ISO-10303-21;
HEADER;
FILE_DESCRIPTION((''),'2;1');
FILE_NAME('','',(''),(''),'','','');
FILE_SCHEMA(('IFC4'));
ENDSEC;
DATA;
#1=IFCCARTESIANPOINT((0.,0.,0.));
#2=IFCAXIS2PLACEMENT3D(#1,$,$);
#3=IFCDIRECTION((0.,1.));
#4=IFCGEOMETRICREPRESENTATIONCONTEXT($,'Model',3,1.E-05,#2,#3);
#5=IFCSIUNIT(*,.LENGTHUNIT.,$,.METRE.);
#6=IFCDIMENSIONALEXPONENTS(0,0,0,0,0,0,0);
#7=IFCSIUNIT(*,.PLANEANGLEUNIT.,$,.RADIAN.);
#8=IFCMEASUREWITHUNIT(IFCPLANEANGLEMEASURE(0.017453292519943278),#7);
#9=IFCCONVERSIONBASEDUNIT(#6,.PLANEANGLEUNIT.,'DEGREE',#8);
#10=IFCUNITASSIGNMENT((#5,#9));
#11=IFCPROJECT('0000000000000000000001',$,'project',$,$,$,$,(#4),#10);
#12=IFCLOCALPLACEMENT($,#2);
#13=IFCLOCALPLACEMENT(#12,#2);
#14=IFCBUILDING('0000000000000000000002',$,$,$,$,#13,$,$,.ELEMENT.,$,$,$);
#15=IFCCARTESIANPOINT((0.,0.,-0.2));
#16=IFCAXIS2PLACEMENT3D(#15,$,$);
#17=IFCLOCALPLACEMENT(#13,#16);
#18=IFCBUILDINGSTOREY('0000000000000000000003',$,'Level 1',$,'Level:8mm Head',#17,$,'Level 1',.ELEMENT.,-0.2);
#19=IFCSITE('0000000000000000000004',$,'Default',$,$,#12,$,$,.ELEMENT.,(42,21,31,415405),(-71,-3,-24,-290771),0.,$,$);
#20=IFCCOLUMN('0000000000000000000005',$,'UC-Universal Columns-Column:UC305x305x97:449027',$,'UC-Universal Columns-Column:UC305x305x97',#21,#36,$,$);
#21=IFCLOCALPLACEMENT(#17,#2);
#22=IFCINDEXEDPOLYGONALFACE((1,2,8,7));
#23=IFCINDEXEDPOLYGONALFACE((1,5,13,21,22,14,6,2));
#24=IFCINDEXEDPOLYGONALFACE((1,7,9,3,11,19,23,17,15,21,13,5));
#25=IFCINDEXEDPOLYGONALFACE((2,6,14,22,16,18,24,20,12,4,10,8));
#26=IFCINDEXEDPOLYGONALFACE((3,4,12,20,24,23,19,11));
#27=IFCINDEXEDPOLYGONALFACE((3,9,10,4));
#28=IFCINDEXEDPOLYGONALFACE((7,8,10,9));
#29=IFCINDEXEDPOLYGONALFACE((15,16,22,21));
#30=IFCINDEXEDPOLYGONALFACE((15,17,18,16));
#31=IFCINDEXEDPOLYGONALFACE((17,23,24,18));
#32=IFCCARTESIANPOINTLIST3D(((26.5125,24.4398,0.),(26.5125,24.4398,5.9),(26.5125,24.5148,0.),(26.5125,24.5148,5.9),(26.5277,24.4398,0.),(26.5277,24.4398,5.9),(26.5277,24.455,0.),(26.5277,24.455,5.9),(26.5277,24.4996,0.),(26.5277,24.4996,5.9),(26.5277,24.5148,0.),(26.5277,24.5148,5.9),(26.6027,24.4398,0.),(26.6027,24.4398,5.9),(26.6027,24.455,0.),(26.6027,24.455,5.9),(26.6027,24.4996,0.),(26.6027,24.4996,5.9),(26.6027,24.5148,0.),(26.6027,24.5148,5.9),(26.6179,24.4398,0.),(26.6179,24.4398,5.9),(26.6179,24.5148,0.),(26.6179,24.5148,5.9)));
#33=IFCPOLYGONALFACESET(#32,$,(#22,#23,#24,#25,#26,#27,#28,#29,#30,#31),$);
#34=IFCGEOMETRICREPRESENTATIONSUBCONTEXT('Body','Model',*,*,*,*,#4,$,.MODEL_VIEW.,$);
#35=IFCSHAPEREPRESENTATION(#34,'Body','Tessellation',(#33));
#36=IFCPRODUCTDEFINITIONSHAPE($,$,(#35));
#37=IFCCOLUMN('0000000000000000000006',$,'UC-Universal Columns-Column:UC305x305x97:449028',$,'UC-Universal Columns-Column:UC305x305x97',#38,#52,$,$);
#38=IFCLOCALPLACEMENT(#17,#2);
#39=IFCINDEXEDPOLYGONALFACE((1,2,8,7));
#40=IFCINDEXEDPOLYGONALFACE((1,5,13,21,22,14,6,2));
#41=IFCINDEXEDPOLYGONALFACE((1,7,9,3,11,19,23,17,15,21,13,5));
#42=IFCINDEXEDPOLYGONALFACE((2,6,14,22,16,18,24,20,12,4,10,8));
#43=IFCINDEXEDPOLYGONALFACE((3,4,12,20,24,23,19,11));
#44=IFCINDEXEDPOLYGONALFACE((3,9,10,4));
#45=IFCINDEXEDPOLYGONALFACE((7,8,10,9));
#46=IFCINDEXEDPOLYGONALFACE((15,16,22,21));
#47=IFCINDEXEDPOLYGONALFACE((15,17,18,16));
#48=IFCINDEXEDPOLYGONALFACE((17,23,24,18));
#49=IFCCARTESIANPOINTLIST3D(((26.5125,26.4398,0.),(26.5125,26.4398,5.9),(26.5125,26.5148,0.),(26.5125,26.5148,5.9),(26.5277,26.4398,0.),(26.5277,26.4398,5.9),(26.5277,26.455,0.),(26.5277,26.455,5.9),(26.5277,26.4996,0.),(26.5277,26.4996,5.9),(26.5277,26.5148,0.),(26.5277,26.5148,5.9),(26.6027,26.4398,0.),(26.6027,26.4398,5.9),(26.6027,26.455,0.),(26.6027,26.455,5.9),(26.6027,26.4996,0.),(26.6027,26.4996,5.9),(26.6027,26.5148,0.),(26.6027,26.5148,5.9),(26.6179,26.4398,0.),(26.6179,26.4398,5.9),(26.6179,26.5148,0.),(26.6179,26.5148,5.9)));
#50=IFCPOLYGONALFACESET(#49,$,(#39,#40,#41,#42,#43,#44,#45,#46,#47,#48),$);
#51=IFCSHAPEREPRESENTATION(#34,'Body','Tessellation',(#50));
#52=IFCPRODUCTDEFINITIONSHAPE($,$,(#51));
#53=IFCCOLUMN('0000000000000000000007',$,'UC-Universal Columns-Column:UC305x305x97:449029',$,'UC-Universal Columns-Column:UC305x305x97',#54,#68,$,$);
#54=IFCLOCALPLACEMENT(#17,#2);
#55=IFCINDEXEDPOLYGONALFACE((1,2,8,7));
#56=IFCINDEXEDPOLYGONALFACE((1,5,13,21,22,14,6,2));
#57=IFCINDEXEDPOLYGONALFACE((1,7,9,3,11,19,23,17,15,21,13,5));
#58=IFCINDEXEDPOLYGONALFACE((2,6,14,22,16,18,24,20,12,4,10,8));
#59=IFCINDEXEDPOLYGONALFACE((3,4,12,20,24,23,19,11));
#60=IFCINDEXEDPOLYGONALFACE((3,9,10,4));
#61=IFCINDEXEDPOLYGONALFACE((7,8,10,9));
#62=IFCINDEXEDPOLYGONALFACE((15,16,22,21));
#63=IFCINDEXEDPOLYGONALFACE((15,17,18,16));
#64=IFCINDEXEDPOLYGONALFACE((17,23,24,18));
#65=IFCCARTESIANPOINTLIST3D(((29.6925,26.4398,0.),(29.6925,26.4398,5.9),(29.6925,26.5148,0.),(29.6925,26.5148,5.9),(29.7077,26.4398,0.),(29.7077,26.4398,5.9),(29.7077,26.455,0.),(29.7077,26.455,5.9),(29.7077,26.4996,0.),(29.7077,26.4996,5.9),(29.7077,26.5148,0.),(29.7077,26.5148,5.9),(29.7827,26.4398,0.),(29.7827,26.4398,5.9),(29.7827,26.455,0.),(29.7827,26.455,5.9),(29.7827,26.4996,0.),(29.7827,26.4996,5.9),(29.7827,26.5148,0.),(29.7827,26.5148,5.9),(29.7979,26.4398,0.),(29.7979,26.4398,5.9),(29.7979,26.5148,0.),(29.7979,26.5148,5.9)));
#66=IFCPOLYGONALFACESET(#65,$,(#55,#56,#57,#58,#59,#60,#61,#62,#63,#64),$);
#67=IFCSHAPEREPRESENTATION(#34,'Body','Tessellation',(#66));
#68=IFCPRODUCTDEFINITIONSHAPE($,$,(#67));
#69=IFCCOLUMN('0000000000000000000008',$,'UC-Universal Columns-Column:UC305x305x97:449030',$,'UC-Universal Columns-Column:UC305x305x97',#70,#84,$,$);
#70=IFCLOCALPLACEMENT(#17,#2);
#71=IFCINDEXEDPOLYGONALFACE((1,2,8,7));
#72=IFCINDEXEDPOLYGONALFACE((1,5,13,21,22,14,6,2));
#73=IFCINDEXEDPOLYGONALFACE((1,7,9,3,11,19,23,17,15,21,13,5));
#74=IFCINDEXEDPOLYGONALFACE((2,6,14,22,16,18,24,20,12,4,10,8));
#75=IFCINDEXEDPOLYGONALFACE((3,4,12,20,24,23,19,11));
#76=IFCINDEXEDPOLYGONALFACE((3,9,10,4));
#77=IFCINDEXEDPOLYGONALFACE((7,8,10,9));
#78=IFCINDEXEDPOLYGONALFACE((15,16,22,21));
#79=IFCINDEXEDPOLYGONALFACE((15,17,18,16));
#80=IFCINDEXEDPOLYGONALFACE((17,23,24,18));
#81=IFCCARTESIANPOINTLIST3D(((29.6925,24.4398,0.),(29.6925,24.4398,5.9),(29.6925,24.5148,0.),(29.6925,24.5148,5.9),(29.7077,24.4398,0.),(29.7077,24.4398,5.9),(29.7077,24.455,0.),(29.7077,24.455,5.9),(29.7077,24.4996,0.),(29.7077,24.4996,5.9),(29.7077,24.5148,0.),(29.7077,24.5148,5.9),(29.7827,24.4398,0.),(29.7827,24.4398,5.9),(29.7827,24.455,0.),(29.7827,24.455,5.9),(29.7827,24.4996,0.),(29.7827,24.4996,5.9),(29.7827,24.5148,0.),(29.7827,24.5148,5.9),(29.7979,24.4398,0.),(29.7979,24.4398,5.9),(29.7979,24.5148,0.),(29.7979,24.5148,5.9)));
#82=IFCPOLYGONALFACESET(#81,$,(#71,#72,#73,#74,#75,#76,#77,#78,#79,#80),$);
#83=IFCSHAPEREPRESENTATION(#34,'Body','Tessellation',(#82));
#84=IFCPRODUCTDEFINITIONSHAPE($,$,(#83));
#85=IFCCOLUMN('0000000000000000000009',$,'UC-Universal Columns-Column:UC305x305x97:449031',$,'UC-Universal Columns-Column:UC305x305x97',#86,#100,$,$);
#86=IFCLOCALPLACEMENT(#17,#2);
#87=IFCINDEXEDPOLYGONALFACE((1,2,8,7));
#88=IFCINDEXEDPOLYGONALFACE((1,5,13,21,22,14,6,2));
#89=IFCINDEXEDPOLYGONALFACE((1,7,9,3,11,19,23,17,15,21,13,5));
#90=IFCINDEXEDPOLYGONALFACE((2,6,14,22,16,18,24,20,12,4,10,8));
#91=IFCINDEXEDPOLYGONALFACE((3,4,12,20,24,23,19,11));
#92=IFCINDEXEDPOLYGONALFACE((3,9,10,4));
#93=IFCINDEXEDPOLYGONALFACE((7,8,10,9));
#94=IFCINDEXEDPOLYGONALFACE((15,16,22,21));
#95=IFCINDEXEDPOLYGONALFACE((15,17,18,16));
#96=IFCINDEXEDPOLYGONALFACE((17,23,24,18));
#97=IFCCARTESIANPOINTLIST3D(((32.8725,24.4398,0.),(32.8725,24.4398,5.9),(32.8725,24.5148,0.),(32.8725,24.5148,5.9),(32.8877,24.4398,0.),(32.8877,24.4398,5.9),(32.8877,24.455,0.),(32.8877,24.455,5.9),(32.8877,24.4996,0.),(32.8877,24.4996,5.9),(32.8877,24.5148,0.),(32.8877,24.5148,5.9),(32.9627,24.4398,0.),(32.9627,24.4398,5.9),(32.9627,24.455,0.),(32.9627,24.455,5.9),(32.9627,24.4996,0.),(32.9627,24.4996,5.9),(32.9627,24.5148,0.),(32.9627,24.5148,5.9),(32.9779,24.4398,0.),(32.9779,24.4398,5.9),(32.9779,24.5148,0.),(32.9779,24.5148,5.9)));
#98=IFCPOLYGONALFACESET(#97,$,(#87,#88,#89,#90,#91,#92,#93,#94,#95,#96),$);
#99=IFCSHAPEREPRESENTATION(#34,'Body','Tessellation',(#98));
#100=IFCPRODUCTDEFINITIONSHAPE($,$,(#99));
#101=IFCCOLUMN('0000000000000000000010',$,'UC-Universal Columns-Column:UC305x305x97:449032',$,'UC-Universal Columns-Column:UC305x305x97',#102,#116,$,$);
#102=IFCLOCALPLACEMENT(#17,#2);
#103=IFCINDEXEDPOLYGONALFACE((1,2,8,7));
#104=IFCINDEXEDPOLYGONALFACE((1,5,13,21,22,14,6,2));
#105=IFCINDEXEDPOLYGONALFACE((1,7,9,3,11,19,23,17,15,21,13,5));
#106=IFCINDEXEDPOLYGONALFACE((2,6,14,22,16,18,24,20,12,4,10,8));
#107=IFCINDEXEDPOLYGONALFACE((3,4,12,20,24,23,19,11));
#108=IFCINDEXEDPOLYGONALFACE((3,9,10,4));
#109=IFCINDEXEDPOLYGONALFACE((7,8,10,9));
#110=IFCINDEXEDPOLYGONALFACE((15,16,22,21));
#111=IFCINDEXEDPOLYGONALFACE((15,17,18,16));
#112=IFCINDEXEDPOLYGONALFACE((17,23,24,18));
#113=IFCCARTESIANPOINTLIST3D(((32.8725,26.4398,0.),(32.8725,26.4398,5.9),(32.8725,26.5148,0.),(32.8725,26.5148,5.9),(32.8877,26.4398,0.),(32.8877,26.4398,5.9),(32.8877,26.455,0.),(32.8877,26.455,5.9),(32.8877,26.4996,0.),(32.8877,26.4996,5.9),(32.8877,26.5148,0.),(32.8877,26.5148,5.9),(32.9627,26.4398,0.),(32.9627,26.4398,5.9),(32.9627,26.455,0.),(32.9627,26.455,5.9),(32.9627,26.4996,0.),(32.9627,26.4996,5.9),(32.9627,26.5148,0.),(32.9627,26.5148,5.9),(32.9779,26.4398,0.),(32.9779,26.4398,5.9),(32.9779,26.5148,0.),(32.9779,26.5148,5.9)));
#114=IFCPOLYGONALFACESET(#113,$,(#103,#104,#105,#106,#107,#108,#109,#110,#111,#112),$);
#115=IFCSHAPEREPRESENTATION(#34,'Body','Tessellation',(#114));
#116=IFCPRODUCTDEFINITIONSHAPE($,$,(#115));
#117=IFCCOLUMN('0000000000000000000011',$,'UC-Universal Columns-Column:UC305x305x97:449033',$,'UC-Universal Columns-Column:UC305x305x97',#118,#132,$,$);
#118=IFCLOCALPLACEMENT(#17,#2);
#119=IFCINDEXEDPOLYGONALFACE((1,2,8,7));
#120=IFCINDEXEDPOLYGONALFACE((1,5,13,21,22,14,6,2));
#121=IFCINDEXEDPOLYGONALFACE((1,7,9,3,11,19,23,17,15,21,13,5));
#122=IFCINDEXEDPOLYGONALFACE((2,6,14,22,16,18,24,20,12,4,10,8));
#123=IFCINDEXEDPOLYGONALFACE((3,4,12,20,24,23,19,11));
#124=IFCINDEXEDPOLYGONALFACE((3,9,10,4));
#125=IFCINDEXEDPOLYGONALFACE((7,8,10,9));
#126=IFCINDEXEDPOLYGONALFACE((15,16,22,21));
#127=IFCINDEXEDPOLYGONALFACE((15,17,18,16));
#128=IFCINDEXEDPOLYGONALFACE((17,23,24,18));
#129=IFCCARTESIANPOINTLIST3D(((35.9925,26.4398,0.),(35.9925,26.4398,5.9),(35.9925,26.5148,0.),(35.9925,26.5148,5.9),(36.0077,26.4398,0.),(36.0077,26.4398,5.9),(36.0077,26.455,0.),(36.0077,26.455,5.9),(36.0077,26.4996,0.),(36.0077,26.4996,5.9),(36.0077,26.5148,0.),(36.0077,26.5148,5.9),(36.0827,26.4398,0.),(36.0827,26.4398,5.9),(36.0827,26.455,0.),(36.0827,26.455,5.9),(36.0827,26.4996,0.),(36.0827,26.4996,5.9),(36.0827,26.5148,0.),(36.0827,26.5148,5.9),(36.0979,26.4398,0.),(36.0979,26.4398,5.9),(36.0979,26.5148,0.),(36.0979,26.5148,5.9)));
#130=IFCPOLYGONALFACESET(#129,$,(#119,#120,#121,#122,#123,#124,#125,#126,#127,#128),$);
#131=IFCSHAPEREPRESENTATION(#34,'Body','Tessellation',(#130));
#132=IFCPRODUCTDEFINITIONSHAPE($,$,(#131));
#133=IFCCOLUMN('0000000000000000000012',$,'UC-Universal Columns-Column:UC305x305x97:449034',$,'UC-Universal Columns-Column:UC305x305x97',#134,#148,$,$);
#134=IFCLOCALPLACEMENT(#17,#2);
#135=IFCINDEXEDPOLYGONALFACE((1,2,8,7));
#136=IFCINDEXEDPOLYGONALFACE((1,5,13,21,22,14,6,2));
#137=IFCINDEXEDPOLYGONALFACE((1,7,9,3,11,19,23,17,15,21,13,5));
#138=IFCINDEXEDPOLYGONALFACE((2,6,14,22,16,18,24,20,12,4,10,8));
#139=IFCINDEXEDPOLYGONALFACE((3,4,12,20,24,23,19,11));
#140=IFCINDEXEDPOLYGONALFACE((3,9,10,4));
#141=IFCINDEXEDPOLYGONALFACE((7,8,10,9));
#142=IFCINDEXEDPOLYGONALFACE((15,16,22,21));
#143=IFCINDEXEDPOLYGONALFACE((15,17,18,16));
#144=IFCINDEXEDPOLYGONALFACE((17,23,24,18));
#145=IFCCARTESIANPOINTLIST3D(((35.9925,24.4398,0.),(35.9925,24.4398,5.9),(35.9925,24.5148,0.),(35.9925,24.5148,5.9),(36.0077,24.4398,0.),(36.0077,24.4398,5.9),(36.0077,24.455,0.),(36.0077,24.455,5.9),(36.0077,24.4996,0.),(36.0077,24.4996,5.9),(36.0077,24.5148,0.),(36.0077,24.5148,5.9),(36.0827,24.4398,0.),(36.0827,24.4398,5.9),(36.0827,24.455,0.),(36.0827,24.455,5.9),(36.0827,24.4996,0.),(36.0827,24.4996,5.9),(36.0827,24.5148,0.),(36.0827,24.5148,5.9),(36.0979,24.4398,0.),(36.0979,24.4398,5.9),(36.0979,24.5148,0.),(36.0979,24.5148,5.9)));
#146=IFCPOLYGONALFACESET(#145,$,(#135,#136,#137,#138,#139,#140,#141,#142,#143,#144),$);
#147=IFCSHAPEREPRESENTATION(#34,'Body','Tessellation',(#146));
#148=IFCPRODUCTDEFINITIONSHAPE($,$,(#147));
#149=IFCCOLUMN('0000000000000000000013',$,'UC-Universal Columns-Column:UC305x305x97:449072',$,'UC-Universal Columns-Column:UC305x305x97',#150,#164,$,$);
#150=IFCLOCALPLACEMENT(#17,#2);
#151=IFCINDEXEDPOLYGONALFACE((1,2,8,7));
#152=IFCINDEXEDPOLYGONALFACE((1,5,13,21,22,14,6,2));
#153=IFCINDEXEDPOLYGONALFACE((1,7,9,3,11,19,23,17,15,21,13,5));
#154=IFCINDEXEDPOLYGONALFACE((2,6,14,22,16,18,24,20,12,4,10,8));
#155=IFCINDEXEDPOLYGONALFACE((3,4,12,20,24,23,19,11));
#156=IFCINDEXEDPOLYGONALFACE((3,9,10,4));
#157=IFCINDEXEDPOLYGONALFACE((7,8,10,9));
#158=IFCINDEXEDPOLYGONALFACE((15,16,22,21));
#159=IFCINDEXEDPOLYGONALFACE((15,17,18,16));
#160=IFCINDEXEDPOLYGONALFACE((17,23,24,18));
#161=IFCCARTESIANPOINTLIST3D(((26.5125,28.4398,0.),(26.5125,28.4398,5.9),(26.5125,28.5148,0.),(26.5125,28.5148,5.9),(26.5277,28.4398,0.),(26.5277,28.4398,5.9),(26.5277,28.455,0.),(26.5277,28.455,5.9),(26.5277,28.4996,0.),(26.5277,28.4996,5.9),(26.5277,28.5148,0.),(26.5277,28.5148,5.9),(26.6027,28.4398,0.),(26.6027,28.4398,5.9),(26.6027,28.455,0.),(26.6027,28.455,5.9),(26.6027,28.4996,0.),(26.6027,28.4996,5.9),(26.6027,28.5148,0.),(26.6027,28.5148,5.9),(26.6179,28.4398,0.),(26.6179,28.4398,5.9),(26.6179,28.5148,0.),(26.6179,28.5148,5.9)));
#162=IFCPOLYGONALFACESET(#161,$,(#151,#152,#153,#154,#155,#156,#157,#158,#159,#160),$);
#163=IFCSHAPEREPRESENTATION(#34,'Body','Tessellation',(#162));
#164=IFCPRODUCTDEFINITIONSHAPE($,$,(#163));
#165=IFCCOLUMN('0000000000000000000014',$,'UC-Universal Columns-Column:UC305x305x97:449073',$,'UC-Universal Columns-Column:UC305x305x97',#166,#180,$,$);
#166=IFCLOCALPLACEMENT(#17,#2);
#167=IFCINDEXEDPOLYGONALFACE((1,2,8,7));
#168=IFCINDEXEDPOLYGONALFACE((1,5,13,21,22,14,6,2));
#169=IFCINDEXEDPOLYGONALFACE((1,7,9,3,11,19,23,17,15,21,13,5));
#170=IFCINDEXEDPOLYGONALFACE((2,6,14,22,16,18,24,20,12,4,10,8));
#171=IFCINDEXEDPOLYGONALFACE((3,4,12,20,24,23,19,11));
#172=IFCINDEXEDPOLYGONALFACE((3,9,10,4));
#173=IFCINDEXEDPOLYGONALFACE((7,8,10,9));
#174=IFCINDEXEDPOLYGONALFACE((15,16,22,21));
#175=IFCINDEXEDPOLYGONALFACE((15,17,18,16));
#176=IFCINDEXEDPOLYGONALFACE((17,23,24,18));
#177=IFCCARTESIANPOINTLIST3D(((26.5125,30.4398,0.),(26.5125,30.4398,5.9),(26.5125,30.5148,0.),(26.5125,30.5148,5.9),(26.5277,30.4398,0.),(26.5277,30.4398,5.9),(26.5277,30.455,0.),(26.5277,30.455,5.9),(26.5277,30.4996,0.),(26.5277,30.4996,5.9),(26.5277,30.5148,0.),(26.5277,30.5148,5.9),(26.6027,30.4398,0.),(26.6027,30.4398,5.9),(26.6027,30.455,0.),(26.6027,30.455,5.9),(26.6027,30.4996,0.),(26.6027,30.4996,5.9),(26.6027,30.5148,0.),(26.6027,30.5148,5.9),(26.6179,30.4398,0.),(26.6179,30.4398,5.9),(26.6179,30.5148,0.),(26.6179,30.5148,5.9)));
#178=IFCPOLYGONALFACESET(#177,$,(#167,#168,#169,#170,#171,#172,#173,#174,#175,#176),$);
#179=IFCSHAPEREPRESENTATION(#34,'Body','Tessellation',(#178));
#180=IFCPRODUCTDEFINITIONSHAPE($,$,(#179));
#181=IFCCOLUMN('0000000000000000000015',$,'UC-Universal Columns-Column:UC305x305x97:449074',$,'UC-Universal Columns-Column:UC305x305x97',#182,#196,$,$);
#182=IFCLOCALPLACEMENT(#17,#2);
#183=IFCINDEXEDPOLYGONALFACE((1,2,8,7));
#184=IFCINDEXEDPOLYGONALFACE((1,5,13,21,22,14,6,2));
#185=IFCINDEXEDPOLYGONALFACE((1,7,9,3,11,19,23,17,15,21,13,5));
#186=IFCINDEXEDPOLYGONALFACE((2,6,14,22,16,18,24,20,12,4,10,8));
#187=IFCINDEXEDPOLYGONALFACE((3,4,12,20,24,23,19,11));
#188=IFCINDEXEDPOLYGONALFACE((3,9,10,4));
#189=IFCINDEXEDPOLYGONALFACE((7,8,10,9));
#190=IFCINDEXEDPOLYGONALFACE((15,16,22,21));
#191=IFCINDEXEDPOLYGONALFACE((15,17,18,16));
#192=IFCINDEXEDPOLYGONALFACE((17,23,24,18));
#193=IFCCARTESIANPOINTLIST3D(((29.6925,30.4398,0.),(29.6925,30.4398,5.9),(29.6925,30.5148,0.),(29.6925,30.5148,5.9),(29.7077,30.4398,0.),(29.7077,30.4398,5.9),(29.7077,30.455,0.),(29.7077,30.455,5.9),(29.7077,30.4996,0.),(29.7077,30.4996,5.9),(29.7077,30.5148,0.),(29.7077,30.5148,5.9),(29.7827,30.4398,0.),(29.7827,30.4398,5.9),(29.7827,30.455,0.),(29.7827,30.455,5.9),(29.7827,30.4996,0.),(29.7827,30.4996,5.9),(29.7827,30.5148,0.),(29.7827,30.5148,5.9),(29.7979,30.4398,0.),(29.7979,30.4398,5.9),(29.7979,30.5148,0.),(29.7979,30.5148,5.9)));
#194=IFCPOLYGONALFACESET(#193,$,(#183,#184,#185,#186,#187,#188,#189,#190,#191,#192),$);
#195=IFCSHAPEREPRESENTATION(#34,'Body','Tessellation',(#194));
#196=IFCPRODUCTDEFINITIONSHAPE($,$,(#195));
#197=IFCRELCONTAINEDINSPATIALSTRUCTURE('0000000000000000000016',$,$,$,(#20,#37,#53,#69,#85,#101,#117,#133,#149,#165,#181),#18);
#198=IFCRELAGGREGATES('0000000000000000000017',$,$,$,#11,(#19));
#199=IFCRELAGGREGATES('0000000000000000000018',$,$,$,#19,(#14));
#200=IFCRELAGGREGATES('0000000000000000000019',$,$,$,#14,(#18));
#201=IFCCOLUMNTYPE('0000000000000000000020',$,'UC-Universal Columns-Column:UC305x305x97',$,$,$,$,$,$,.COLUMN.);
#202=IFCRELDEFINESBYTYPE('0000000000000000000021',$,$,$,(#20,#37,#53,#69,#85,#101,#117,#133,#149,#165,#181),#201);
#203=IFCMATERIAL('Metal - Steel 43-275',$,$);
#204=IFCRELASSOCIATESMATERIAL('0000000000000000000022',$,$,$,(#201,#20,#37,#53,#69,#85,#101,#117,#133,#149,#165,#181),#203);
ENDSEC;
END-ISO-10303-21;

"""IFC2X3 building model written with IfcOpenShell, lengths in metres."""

from ifc_helpers import new_model, entity, si_unit, converted_unit, direction, frame, frame_2d, origin, place, context, subcontext, project, spatial, polyline, circle_curve, parameter, trimmed, segment, composite_curve, outline, extrude, source, transform, mapped, material, type_object, type_shapes, element, save


model = new_model("IFC2X3")

# Units and contexts
model_context = context("Model", 3, precision=1e-05, world=origin(), true_north=direction((0.0, 1.0)))
body_context = subcontext(model_context, "Body", "Model", "MODEL_VIEW")
ifc_project = project(units=[si_unit("LENGTHUNIT", "METRE"), converted_unit("PLANEANGLEUNIT", "DEGREE", entity("IfcPlaneAngleMeasure", 0.017453292519943278), si_unit("PLANEANGLEUNIT", "RADIAN"), dimensions=[0, 0, 0, 0, 0, 0, 0])], contexts=[model_context])

# Site, building, storey
site_placement = place(None, origin())
site = spatial("IfcSite", under=ifc_project, at=site_placement, Name="Default", CompositionType="ELEMENT", RefLatitude=(42, 21, 31, 415405), RefLongitude=(-71, -3, -24, -290771), RefElevation=0.0)
building_placement = place(site_placement, origin())
building = spatial("IfcBuilding", under=site, at=building_placement, CompositionType="ELEMENT")
storey_placement = place(building_placement, frame((0.0, 0.0, -0.2)))
storey = spatial("IfcBuildingStorey", under=building, at=storey_placement, Name="Level 1", ObjectType="Level:8mm Head", LongName="Level 1", CompositionType="ELEMENT", Elevation=-0.2)

# Columns
ifc_material = material(Name="Metal - Steel 43-275")
column_type = type_object("IfcColumnType", Name="UC-Universal Columns-Column:UC305x305x97", PredefinedType="COLUMN", material=ifc_material)
shared_shape = source(origin(), body_context, "Body", "SweptSolid", [
    extrude(outline(composite_curve([segment(polyline([(-0.0375, -0.0375), (0.0375, -0.0375)]), True, "CONTINUOUS"), segment(polyline([(0.0375, -0.0375), (0.0527, -0.0375)]), True, "CONTINUOUS"), segment(trimmed(circle_curve(frame_2d((0.0527, -0.0223), x_axis=(-1.0, 0.0)), 0.0152), [parameter(0.0)], [parameter(90.0)], True, "PARAMETER"), False, "CONTINUOUS"), segment(polyline([(0.0375, -0.0223), (0.0375, 0.0223)]), True, "CONTINUOUS"), segment(trimmed(circle_curve(frame_2d((0.0527, 0.0223), x_axis=(-1.0, 0.0)), 0.0152), [parameter(270.0)], [parameter(0.0)], True, "PARAMETER"), False, "CONTINUOUS"), segment(polyline([(0.0527, 0.0375), (0.0375, 0.0375)]), True, "CONTINUOUS"), segment(polyline([(0.0375, 0.0375), (-0.0375, 0.0375)]), True, "CONTINUOUS"), segment(polyline([(-0.0375, 0.0375), (-0.0527, 0.0375)]), True, "CONTINUOUS"), segment(trimmed(circle_curve(frame_2d((-0.0527, 0.0223), x_axis=(-1.0, 0.0)), 0.0152), [parameter(180.0)], [parameter(270.0)], True, "PARAMETER"), False, "CONTINUOUS"), segment(polyline([(-0.0375, 0.0223), (-0.0375, -0.0223)]), True, "CONTINUOUS"), segment(trimmed(circle_curve(frame_2d((-0.0527, -0.0223), x_axis=(-1.0, 0.0)), 0.0152), [parameter(90.0)], [parameter(180.0)], True, "PARAMETER"), False, "CONTINUOUS"), segment(polyline([(-0.0527, -0.0375), (-0.0375, -0.0375)]), True, "CONTINUOUS")], self_intersect=False)), frame((0.0, 0.0, -0.2), z_axis=(0.0, 0.0, 1.0), x_axis=(-1.0, 0.0, 0.0)), (0.0, 0.0, 1.0), 5.9),
])
type_shapes(column_type, [shared_shape])
for number, where, z_axis, x_axis, name in (
    (1, (26.5652, 24.4773, 0.2), (0.0, 0.0, 1.0), (-1.0, 0.0, 0.0), "UC-Universal Columns-Column:UC305x305x97:449027"),
    (2, (26.5652, 26.4773, 0.2), (0.0, 0.0, 1.0), (-1.0, 0.0, 0.0), "UC-Universal Columns-Column:UC305x305x97:449028"),
    (3, (29.7452, 26.4773, 0.2), (0.0, 0.0, 1.0), (-1.0, 0.0, 0.0), "UC-Universal Columns-Column:UC305x305x97:449029"),
    (4, (29.7452, 24.4773, 0.2), (0.0, 0.0, 1.0), (-1.0, 0.0, 0.0), "UC-Universal Columns-Column:UC305x305x97:449030"),
    (5, (32.9252, 24.4773, 0.2), (0.0, 0.0, 1.0), (-1.0, 0.0, 0.0), "UC-Universal Columns-Column:UC305x305x97:449031"),
    (6, (32.9252, 26.4773, 0.2), (0.0, 0.0, 1.0), (-1.0, 0.0, 0.0), "UC-Universal Columns-Column:UC305x305x97:449032"),
    (7, (36.0452, 26.4773, 0.2), (0.0, 0.0, 1.0), (-1.0, 0.0, 0.0), "UC-Universal Columns-Column:UC305x305x97:449033"),
    (8, (36.0452, 24.4773, 0.2), (0.0, 0.0, 1.0), (-1.0, 0.0, 0.0), "UC-Universal Columns-Column:UC305x305x97:449034"),
    (9, (26.5652, 28.4773, 0.2), (0.0, 0.0, 1.0), (-1.0, 0.0, 0.0), "UC-Universal Columns-Column:UC305x305x97:449072"),
    (10, (26.5652, 30.4773, 0.2), (0.0, 0.0, 1.0), (-1.0, 0.0, 0.0), "UC-Universal Columns-Column:UC305x305x97:449073"),
    (11, (29.7452, 30.4773, 0.2), (0.0, 0.0, 1.0), (-1.0, 0.0, 0.0), "UC-Universal Columns-Column:UC305x305x97:449074"),
):
    element("IfcColumn", number, at=place(storey_placement, frame(where, z_axis=z_axis, x_axis=x_axis)), inside=storey, type_object=column_type, material=ifc_material, Name=name, ObjectType="UC-Universal Columns-Column:UC305x305x97", context=body_context, shape_type="MappedRepresentation", body=[
        mapped(shared_shape, transform((0.0, 0.0, 0.0), scale=1.0)),
    ])

save(model, "model.ifc")
